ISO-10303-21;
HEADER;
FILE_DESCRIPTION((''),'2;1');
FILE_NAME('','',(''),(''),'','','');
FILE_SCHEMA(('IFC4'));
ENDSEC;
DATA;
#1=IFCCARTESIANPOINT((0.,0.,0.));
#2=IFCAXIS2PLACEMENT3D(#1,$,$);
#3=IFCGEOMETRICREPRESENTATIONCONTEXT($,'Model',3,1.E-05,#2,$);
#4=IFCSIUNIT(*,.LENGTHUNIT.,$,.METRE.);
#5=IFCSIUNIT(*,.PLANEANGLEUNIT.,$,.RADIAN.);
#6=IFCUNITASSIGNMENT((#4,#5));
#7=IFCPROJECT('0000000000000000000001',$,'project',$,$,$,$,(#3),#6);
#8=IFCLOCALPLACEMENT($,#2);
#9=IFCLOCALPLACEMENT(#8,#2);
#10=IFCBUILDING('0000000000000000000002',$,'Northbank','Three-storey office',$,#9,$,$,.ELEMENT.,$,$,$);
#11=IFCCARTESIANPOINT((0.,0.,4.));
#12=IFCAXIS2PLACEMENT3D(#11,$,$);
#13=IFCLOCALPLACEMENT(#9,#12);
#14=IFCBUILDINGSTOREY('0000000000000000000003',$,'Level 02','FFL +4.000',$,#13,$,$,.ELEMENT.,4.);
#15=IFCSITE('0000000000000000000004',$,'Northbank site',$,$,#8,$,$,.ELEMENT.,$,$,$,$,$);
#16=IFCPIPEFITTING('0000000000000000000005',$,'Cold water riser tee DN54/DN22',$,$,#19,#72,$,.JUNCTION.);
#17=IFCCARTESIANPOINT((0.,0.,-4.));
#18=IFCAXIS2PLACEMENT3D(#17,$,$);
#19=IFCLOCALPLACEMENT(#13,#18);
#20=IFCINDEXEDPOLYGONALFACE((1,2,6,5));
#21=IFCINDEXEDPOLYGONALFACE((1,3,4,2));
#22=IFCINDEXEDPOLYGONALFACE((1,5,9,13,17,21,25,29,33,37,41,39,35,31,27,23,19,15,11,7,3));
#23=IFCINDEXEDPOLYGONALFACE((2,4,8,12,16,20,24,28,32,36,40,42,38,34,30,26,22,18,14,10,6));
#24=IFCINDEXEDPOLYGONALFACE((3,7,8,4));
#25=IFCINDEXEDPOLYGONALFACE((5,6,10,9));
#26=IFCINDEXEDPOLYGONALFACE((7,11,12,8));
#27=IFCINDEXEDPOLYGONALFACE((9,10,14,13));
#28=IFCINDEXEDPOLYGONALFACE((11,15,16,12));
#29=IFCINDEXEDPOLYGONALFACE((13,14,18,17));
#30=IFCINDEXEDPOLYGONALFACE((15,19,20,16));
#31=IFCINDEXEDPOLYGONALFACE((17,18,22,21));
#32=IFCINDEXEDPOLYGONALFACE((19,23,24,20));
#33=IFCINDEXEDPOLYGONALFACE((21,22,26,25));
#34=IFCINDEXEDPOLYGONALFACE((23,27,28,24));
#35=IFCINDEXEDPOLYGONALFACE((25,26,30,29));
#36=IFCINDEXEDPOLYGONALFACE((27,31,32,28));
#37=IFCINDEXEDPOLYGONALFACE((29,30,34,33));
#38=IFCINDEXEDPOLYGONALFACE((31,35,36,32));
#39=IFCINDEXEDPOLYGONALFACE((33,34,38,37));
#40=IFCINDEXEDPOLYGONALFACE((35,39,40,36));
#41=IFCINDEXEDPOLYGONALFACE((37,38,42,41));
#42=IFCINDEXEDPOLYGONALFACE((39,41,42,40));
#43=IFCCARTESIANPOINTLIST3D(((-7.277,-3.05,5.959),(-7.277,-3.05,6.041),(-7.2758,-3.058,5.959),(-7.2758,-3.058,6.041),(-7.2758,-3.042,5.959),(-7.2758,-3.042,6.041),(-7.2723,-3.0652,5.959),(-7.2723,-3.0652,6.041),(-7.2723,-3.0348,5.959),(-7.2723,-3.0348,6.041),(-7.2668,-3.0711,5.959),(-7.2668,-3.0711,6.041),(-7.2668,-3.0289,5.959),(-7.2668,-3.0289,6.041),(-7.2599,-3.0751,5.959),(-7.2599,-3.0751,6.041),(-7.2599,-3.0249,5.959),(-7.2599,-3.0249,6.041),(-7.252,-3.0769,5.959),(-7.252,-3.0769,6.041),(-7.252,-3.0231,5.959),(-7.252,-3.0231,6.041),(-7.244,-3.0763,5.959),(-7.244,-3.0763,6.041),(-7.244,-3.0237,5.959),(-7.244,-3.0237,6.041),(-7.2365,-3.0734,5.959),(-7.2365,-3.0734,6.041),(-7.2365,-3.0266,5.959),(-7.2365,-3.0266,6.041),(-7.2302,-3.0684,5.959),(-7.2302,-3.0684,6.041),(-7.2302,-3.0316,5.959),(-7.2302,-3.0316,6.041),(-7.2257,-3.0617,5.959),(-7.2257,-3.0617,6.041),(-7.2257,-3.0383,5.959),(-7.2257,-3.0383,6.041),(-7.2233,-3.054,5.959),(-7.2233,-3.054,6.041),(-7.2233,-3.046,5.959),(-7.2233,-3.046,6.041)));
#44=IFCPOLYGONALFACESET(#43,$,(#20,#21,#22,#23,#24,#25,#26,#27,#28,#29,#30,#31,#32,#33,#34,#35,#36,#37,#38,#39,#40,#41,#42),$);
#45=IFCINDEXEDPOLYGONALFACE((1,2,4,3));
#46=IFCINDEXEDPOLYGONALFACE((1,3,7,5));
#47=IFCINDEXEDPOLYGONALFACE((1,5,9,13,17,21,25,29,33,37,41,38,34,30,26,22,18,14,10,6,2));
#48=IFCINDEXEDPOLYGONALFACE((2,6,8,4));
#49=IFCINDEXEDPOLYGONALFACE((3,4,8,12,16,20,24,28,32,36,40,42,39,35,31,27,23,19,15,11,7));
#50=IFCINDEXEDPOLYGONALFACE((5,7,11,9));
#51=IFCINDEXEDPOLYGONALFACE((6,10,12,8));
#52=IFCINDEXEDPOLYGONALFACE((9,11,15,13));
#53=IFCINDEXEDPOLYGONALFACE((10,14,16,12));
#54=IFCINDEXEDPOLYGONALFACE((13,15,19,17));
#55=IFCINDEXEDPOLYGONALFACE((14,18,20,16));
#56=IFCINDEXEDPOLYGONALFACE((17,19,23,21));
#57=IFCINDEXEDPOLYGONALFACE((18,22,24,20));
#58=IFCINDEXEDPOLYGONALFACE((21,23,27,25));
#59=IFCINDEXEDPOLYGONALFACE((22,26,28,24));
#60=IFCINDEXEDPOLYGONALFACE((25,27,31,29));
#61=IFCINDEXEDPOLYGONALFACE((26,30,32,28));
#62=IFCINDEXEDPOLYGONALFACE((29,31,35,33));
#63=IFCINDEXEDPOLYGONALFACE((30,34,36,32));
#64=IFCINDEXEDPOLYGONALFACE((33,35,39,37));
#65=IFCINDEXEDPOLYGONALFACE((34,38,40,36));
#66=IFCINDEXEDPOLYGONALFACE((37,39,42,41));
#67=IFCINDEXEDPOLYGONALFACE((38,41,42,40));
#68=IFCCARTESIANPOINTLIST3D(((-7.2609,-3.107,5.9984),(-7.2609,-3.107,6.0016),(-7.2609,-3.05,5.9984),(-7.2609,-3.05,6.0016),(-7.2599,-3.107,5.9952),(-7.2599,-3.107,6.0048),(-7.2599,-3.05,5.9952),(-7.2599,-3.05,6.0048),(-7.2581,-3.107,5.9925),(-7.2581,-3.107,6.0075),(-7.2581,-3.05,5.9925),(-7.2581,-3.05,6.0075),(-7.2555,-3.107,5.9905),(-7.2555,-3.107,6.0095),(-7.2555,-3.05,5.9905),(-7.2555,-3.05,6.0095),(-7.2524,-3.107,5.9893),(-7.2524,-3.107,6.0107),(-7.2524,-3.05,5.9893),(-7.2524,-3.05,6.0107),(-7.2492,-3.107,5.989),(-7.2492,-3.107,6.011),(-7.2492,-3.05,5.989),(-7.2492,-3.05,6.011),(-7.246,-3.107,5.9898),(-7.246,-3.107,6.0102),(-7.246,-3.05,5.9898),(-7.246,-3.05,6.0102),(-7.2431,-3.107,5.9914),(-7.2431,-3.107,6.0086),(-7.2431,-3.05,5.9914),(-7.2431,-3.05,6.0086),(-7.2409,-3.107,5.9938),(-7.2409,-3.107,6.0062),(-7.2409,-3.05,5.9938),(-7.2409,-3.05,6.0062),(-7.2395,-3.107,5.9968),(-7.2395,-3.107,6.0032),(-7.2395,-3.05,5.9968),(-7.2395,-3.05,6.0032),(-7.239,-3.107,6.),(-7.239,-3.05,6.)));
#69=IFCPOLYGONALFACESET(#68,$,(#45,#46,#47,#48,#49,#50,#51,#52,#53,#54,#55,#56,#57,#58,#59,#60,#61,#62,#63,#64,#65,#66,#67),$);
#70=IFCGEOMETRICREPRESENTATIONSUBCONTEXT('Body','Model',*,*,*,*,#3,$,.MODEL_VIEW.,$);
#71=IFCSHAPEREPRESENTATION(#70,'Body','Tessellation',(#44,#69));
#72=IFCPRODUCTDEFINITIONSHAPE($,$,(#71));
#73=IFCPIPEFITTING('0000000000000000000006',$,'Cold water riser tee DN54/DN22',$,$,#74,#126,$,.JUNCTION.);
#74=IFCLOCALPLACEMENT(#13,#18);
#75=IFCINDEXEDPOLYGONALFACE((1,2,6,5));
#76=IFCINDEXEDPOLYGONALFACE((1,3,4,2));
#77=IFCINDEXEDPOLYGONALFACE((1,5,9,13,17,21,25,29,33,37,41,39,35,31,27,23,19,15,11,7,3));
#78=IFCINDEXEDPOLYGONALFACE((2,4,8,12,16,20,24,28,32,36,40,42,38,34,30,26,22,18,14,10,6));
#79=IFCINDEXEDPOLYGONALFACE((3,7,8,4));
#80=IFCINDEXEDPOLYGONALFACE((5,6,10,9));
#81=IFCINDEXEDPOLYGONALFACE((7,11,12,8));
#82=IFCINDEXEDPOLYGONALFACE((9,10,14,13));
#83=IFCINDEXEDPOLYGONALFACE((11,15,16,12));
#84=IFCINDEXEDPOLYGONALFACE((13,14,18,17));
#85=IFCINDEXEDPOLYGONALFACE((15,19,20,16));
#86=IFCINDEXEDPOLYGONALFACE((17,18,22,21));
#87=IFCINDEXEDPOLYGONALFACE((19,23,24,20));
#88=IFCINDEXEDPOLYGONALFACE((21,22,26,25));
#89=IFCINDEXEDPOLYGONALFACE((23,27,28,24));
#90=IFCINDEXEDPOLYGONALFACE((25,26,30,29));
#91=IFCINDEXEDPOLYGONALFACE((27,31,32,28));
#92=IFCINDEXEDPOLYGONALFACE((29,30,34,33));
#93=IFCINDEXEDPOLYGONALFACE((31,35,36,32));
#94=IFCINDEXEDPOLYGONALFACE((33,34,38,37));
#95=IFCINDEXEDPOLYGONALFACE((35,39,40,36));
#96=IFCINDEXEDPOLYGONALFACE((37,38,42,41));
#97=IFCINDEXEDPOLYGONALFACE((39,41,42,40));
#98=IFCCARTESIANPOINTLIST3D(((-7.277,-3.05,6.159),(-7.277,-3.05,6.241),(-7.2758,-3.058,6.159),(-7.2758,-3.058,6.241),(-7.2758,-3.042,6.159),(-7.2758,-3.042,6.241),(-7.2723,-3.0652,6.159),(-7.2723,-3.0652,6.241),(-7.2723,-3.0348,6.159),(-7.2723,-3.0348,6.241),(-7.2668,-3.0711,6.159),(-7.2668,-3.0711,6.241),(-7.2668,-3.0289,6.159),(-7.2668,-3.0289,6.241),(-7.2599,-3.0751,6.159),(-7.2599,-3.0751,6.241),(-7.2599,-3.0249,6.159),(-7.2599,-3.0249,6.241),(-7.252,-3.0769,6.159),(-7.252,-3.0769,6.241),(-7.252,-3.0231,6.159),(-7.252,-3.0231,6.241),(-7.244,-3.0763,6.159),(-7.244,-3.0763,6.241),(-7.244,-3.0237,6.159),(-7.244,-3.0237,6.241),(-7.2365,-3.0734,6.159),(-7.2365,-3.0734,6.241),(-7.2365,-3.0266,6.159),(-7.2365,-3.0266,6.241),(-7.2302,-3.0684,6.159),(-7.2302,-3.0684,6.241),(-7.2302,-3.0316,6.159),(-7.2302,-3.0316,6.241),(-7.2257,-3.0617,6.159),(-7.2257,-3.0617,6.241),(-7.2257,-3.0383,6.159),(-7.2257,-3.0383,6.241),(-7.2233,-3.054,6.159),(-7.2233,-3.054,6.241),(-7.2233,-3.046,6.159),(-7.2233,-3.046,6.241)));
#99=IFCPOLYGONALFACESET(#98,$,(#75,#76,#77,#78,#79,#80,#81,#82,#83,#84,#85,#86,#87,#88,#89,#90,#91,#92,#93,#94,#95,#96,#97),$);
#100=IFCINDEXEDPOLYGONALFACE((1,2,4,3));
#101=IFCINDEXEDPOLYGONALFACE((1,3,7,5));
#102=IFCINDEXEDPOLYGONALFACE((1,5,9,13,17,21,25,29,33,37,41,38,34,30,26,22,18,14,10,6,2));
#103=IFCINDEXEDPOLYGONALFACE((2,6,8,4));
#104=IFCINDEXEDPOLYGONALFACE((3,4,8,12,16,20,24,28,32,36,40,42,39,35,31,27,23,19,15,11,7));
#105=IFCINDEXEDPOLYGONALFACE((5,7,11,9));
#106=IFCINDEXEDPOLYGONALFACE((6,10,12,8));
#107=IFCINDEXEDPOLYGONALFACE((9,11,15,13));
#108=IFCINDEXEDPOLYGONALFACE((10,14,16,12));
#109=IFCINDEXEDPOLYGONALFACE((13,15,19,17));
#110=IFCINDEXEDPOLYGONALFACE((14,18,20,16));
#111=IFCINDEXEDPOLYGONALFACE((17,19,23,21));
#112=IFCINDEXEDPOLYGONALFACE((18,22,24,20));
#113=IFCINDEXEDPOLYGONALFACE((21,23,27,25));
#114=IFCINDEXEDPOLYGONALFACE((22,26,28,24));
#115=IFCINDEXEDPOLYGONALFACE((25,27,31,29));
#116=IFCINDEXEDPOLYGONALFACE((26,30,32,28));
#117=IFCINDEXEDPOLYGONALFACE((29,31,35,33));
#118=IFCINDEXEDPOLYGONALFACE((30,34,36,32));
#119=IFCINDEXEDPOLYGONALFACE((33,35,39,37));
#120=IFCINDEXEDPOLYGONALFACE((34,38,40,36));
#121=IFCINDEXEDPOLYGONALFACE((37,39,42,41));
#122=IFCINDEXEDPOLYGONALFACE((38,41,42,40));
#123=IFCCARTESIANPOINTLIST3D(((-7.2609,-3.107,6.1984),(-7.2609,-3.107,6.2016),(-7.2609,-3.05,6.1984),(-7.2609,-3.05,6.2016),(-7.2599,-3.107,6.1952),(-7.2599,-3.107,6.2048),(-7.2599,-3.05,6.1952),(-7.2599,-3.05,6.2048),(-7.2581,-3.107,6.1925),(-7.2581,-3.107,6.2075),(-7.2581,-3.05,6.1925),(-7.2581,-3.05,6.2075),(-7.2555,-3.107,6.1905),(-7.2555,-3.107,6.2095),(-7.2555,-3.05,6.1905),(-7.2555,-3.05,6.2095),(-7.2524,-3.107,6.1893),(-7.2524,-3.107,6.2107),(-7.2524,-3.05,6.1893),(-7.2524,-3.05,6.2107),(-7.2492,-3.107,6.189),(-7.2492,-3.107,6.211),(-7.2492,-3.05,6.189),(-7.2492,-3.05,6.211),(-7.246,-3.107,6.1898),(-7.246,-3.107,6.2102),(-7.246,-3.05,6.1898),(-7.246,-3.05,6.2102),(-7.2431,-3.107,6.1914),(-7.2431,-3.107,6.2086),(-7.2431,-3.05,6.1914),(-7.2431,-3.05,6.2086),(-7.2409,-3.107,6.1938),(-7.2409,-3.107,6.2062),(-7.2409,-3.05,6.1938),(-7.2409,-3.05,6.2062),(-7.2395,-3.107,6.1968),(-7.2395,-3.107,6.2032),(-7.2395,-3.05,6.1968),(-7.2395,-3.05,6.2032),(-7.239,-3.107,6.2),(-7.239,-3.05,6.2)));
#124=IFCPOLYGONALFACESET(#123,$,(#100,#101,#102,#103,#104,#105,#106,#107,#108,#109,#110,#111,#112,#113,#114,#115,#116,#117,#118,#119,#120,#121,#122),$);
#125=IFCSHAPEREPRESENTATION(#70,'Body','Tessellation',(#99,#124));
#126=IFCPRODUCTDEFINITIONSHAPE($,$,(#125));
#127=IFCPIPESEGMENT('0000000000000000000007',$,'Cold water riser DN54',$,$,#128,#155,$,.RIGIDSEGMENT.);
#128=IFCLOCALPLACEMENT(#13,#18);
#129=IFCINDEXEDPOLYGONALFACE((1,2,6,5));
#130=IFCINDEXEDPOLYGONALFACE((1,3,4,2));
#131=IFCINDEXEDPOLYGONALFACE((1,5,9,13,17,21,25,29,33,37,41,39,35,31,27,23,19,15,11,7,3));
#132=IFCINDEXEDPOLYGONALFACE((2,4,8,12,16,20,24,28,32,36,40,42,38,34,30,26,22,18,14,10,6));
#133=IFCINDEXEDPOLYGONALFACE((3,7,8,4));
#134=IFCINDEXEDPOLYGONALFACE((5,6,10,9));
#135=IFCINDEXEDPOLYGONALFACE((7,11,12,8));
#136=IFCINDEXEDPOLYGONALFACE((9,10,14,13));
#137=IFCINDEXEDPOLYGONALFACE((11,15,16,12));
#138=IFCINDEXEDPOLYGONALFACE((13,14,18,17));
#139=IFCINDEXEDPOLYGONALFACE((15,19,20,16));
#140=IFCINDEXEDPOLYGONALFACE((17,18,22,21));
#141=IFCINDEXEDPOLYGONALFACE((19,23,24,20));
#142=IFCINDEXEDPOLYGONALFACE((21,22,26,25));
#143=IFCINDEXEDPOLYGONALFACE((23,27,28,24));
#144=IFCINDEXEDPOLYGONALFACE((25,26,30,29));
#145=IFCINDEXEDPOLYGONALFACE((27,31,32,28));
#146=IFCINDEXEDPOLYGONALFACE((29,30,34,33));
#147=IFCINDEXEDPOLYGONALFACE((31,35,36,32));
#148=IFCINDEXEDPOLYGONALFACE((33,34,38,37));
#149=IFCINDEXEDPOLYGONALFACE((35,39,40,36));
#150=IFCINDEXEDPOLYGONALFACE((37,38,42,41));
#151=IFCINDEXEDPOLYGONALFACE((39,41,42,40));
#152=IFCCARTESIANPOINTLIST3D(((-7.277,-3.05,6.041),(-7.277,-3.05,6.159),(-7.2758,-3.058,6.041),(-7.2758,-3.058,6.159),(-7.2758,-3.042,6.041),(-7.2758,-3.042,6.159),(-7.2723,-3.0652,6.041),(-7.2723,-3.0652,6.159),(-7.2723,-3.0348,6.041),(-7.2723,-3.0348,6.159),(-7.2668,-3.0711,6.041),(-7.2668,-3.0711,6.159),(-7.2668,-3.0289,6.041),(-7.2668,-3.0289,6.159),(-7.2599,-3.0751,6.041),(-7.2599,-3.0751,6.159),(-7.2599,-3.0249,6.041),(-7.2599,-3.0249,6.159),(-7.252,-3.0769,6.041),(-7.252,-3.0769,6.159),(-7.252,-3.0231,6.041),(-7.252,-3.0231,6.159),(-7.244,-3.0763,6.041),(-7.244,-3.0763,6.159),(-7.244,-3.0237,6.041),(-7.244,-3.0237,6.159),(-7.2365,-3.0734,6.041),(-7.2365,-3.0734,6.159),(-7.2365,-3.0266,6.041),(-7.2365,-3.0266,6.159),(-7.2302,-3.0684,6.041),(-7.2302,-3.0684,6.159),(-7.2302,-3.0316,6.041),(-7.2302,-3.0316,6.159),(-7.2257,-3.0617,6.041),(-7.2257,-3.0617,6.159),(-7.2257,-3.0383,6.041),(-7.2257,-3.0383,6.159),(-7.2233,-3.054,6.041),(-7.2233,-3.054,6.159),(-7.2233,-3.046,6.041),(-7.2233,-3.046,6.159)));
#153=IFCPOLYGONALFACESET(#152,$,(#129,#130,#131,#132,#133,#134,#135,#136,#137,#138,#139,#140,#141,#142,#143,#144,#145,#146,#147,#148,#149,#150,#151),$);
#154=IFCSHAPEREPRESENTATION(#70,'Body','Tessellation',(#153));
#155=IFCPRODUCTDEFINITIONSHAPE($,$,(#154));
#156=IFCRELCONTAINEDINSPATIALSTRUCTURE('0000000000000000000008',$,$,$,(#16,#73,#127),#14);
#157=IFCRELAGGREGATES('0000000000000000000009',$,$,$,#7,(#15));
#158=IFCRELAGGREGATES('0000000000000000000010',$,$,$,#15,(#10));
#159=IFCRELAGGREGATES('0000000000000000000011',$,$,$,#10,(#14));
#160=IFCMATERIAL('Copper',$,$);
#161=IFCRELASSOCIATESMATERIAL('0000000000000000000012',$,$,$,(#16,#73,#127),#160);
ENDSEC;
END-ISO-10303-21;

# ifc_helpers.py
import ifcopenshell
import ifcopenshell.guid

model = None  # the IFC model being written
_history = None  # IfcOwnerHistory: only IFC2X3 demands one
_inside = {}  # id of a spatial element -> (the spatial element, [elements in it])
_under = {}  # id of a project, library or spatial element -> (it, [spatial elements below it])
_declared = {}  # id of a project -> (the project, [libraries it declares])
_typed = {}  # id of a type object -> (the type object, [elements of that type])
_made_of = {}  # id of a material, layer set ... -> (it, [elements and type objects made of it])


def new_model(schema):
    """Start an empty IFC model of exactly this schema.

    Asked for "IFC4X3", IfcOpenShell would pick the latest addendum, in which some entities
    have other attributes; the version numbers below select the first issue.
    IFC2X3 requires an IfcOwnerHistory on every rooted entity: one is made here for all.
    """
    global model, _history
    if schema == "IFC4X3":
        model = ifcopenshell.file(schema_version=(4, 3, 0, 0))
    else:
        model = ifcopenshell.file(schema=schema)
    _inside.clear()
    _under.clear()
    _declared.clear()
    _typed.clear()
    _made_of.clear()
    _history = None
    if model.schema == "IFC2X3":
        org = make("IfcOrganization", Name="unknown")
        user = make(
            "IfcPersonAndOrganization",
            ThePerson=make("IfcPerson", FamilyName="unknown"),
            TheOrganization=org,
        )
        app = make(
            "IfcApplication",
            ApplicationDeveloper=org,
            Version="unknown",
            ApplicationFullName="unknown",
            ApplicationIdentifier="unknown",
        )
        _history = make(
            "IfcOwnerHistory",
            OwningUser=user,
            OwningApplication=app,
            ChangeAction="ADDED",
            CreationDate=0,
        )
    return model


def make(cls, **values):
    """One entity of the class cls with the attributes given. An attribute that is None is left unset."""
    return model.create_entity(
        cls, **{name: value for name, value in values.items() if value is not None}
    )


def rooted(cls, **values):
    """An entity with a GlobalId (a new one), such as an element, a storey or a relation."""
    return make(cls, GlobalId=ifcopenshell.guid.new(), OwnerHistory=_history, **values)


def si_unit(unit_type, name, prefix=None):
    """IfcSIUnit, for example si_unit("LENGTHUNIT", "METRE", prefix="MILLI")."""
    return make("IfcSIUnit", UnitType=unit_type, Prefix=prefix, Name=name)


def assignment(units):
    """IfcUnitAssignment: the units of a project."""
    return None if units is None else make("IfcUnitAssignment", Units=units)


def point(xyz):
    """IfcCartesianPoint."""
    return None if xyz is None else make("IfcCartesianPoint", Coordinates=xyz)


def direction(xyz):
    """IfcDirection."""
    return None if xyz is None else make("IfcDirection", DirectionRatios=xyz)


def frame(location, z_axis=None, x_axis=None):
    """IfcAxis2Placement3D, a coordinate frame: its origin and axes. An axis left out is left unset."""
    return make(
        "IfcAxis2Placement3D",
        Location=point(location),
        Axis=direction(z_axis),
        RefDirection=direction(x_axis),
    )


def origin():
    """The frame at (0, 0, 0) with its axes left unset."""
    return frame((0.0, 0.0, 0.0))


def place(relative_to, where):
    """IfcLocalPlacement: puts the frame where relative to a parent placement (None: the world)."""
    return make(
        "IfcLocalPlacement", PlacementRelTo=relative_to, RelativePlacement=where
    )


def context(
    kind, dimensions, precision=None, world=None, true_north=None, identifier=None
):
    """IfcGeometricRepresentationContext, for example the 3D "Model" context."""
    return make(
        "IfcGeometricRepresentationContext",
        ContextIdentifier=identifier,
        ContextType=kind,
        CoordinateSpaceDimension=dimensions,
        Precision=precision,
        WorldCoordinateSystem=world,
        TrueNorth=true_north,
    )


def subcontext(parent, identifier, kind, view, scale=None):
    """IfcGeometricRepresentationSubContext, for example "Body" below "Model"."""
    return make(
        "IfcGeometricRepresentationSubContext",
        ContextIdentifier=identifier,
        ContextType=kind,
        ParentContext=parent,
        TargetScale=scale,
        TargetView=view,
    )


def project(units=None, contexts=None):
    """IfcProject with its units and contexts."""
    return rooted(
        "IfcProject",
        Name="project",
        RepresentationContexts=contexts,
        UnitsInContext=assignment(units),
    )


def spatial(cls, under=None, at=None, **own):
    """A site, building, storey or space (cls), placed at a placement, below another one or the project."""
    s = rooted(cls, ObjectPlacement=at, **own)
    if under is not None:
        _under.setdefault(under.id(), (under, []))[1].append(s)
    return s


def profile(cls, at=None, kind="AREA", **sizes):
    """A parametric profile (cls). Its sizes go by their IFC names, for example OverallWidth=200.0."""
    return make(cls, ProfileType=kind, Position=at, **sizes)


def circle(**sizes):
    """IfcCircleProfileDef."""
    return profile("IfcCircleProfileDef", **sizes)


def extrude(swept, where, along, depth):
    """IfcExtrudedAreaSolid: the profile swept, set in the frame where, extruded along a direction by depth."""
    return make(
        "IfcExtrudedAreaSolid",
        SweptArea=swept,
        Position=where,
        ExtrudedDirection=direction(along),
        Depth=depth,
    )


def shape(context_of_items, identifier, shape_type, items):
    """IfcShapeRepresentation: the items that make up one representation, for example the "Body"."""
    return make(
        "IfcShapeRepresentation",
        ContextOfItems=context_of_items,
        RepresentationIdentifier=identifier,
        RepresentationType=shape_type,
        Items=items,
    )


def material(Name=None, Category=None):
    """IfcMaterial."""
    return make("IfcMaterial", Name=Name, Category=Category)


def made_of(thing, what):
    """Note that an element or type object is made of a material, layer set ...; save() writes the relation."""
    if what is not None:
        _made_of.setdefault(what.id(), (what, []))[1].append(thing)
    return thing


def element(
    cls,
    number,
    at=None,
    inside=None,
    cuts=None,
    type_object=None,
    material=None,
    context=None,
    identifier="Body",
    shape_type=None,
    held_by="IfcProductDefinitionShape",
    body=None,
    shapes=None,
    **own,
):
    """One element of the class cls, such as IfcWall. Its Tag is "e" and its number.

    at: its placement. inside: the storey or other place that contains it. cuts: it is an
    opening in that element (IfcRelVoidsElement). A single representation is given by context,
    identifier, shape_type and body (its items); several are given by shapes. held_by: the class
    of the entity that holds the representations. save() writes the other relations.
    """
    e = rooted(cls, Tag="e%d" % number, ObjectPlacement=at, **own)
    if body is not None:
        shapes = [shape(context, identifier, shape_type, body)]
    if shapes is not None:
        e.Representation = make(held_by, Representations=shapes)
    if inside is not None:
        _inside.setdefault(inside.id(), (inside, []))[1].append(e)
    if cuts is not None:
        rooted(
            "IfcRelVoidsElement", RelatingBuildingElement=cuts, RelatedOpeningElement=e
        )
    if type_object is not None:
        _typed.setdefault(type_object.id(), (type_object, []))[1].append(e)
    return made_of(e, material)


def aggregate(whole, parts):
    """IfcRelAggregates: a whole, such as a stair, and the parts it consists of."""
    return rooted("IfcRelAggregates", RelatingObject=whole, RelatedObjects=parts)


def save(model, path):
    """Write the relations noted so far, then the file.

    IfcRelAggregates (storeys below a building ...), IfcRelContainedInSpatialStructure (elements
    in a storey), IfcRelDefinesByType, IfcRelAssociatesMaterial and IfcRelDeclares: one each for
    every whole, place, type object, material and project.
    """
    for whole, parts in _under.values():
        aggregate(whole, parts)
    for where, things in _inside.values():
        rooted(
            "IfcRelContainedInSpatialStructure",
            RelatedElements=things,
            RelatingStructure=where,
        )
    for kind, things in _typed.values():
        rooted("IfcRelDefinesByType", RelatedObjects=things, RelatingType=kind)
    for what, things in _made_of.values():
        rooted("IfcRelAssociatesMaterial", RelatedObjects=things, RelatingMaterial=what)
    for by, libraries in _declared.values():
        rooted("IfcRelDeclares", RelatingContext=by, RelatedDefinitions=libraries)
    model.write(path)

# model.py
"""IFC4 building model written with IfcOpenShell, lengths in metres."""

from ifc_helpers import new_model, si_unit, frame, origin, place, context, subcontext, project, spatial, circle, extrude, material, element, save


model = new_model("IFC4")

# Units and contexts
model_context = context("Model", 3, precision=1e-05, world=origin())
body_context = subcontext(model_context, "Body", "Model", "MODEL_VIEW")
ifc_project = project(units=[si_unit("LENGTHUNIT", "METRE"), si_unit("PLANEANGLEUNIT", "RADIAN")], contexts=[model_context])

# Site, building, storey
site_placement = place(None, origin())
site = spatial("IfcSite", under=ifc_project, at=site_placement, Name="Northbank site", CompositionType="ELEMENT")
building_placement = place(site_placement, origin())
building = spatial("IfcBuilding", under=site, at=building_placement, Name="Northbank", Description="Three-storey office", CompositionType="ELEMENT")
storey_placement = place(building_placement, frame((0.0, 0.0, 4.0)))
storey = spatial("IfcBuildingStorey", under=building, at=storey_placement, Name="Level 02", Description="FFL +4.000", CompositionType="ELEMENT", Elevation=4.0)

# Pipe fittings
ifc_material_1 = material(Name="Copper")
pipe_fitting_1_placement = place(storey_placement, frame((0.0, 0.0, -4.0)))
element("IfcPipeFitting", 1, at=pipe_fitting_1_placement, inside=storey, material=ifc_material_1, Name="Cold water riser tee DN54/DN22", PredefinedType="JUNCTION", context=body_context, shape_type="SweptSolid", body=[
    extrude(circle(Radius=0.027), frame((-7.25, -3.05, 5.959), z_axis=(0.0, 0.0, 1.0), x_axis=(-1.0, 0.0, 0.0)), (0.0, 0.0, 1.0), 0.082),
    extrude(circle(Radius=0.011), frame((-7.25, -3.05, 6.0), z_axis=(0.0, -1.0, 0.0), x_axis=(1.0, 0.0, 0.0)), (0.0, 0.0, 1.0), 0.057),
])
pipe_fitting_2_placement = place(storey_placement, frame((0.0, 0.0, -4.0)))
element("IfcPipeFitting", 2, at=pipe_fitting_2_placement, inside=storey, material=ifc_material_1, Name="Cold water riser tee DN54/DN22", PredefinedType="JUNCTION", context=body_context, shape_type="SweptSolid", body=[
    extrude(circle(Radius=0.027), frame((-7.25, -3.05, 6.159), z_axis=(0.0, 0.0, 1.0), x_axis=(-1.0, 0.0, 0.0)), (0.0, 0.0, 1.0), 0.082),
    extrude(circle(Radius=0.011), frame((-7.25, -3.05, 6.2), z_axis=(0.0, -1.0, 0.0), x_axis=(1.0, 0.0, 0.0)), (0.0, 0.0, 1.0), 0.057),
])

# Pipe segment
pipe_segment_placement = place(storey_placement, frame((0.0, 0.0, -4.0)))
element("IfcPipeSegment", 3, at=pipe_segment_placement, inside=storey, material=ifc_material_1, Name="Cold water riser DN54", PredefinedType="RIGIDSEGMENT", context=body_context, shape_type="SweptSolid", body=[
    extrude(circle(Radius=0.027), frame((-7.25, -3.05, 6.041), z_axis=(0.0, 0.0, 1.0), x_axis=(-1.0, 0.0, 0.0)), (0.0, 0.0, 1.0), 0.118),
])

save(model, "model.ifc")
